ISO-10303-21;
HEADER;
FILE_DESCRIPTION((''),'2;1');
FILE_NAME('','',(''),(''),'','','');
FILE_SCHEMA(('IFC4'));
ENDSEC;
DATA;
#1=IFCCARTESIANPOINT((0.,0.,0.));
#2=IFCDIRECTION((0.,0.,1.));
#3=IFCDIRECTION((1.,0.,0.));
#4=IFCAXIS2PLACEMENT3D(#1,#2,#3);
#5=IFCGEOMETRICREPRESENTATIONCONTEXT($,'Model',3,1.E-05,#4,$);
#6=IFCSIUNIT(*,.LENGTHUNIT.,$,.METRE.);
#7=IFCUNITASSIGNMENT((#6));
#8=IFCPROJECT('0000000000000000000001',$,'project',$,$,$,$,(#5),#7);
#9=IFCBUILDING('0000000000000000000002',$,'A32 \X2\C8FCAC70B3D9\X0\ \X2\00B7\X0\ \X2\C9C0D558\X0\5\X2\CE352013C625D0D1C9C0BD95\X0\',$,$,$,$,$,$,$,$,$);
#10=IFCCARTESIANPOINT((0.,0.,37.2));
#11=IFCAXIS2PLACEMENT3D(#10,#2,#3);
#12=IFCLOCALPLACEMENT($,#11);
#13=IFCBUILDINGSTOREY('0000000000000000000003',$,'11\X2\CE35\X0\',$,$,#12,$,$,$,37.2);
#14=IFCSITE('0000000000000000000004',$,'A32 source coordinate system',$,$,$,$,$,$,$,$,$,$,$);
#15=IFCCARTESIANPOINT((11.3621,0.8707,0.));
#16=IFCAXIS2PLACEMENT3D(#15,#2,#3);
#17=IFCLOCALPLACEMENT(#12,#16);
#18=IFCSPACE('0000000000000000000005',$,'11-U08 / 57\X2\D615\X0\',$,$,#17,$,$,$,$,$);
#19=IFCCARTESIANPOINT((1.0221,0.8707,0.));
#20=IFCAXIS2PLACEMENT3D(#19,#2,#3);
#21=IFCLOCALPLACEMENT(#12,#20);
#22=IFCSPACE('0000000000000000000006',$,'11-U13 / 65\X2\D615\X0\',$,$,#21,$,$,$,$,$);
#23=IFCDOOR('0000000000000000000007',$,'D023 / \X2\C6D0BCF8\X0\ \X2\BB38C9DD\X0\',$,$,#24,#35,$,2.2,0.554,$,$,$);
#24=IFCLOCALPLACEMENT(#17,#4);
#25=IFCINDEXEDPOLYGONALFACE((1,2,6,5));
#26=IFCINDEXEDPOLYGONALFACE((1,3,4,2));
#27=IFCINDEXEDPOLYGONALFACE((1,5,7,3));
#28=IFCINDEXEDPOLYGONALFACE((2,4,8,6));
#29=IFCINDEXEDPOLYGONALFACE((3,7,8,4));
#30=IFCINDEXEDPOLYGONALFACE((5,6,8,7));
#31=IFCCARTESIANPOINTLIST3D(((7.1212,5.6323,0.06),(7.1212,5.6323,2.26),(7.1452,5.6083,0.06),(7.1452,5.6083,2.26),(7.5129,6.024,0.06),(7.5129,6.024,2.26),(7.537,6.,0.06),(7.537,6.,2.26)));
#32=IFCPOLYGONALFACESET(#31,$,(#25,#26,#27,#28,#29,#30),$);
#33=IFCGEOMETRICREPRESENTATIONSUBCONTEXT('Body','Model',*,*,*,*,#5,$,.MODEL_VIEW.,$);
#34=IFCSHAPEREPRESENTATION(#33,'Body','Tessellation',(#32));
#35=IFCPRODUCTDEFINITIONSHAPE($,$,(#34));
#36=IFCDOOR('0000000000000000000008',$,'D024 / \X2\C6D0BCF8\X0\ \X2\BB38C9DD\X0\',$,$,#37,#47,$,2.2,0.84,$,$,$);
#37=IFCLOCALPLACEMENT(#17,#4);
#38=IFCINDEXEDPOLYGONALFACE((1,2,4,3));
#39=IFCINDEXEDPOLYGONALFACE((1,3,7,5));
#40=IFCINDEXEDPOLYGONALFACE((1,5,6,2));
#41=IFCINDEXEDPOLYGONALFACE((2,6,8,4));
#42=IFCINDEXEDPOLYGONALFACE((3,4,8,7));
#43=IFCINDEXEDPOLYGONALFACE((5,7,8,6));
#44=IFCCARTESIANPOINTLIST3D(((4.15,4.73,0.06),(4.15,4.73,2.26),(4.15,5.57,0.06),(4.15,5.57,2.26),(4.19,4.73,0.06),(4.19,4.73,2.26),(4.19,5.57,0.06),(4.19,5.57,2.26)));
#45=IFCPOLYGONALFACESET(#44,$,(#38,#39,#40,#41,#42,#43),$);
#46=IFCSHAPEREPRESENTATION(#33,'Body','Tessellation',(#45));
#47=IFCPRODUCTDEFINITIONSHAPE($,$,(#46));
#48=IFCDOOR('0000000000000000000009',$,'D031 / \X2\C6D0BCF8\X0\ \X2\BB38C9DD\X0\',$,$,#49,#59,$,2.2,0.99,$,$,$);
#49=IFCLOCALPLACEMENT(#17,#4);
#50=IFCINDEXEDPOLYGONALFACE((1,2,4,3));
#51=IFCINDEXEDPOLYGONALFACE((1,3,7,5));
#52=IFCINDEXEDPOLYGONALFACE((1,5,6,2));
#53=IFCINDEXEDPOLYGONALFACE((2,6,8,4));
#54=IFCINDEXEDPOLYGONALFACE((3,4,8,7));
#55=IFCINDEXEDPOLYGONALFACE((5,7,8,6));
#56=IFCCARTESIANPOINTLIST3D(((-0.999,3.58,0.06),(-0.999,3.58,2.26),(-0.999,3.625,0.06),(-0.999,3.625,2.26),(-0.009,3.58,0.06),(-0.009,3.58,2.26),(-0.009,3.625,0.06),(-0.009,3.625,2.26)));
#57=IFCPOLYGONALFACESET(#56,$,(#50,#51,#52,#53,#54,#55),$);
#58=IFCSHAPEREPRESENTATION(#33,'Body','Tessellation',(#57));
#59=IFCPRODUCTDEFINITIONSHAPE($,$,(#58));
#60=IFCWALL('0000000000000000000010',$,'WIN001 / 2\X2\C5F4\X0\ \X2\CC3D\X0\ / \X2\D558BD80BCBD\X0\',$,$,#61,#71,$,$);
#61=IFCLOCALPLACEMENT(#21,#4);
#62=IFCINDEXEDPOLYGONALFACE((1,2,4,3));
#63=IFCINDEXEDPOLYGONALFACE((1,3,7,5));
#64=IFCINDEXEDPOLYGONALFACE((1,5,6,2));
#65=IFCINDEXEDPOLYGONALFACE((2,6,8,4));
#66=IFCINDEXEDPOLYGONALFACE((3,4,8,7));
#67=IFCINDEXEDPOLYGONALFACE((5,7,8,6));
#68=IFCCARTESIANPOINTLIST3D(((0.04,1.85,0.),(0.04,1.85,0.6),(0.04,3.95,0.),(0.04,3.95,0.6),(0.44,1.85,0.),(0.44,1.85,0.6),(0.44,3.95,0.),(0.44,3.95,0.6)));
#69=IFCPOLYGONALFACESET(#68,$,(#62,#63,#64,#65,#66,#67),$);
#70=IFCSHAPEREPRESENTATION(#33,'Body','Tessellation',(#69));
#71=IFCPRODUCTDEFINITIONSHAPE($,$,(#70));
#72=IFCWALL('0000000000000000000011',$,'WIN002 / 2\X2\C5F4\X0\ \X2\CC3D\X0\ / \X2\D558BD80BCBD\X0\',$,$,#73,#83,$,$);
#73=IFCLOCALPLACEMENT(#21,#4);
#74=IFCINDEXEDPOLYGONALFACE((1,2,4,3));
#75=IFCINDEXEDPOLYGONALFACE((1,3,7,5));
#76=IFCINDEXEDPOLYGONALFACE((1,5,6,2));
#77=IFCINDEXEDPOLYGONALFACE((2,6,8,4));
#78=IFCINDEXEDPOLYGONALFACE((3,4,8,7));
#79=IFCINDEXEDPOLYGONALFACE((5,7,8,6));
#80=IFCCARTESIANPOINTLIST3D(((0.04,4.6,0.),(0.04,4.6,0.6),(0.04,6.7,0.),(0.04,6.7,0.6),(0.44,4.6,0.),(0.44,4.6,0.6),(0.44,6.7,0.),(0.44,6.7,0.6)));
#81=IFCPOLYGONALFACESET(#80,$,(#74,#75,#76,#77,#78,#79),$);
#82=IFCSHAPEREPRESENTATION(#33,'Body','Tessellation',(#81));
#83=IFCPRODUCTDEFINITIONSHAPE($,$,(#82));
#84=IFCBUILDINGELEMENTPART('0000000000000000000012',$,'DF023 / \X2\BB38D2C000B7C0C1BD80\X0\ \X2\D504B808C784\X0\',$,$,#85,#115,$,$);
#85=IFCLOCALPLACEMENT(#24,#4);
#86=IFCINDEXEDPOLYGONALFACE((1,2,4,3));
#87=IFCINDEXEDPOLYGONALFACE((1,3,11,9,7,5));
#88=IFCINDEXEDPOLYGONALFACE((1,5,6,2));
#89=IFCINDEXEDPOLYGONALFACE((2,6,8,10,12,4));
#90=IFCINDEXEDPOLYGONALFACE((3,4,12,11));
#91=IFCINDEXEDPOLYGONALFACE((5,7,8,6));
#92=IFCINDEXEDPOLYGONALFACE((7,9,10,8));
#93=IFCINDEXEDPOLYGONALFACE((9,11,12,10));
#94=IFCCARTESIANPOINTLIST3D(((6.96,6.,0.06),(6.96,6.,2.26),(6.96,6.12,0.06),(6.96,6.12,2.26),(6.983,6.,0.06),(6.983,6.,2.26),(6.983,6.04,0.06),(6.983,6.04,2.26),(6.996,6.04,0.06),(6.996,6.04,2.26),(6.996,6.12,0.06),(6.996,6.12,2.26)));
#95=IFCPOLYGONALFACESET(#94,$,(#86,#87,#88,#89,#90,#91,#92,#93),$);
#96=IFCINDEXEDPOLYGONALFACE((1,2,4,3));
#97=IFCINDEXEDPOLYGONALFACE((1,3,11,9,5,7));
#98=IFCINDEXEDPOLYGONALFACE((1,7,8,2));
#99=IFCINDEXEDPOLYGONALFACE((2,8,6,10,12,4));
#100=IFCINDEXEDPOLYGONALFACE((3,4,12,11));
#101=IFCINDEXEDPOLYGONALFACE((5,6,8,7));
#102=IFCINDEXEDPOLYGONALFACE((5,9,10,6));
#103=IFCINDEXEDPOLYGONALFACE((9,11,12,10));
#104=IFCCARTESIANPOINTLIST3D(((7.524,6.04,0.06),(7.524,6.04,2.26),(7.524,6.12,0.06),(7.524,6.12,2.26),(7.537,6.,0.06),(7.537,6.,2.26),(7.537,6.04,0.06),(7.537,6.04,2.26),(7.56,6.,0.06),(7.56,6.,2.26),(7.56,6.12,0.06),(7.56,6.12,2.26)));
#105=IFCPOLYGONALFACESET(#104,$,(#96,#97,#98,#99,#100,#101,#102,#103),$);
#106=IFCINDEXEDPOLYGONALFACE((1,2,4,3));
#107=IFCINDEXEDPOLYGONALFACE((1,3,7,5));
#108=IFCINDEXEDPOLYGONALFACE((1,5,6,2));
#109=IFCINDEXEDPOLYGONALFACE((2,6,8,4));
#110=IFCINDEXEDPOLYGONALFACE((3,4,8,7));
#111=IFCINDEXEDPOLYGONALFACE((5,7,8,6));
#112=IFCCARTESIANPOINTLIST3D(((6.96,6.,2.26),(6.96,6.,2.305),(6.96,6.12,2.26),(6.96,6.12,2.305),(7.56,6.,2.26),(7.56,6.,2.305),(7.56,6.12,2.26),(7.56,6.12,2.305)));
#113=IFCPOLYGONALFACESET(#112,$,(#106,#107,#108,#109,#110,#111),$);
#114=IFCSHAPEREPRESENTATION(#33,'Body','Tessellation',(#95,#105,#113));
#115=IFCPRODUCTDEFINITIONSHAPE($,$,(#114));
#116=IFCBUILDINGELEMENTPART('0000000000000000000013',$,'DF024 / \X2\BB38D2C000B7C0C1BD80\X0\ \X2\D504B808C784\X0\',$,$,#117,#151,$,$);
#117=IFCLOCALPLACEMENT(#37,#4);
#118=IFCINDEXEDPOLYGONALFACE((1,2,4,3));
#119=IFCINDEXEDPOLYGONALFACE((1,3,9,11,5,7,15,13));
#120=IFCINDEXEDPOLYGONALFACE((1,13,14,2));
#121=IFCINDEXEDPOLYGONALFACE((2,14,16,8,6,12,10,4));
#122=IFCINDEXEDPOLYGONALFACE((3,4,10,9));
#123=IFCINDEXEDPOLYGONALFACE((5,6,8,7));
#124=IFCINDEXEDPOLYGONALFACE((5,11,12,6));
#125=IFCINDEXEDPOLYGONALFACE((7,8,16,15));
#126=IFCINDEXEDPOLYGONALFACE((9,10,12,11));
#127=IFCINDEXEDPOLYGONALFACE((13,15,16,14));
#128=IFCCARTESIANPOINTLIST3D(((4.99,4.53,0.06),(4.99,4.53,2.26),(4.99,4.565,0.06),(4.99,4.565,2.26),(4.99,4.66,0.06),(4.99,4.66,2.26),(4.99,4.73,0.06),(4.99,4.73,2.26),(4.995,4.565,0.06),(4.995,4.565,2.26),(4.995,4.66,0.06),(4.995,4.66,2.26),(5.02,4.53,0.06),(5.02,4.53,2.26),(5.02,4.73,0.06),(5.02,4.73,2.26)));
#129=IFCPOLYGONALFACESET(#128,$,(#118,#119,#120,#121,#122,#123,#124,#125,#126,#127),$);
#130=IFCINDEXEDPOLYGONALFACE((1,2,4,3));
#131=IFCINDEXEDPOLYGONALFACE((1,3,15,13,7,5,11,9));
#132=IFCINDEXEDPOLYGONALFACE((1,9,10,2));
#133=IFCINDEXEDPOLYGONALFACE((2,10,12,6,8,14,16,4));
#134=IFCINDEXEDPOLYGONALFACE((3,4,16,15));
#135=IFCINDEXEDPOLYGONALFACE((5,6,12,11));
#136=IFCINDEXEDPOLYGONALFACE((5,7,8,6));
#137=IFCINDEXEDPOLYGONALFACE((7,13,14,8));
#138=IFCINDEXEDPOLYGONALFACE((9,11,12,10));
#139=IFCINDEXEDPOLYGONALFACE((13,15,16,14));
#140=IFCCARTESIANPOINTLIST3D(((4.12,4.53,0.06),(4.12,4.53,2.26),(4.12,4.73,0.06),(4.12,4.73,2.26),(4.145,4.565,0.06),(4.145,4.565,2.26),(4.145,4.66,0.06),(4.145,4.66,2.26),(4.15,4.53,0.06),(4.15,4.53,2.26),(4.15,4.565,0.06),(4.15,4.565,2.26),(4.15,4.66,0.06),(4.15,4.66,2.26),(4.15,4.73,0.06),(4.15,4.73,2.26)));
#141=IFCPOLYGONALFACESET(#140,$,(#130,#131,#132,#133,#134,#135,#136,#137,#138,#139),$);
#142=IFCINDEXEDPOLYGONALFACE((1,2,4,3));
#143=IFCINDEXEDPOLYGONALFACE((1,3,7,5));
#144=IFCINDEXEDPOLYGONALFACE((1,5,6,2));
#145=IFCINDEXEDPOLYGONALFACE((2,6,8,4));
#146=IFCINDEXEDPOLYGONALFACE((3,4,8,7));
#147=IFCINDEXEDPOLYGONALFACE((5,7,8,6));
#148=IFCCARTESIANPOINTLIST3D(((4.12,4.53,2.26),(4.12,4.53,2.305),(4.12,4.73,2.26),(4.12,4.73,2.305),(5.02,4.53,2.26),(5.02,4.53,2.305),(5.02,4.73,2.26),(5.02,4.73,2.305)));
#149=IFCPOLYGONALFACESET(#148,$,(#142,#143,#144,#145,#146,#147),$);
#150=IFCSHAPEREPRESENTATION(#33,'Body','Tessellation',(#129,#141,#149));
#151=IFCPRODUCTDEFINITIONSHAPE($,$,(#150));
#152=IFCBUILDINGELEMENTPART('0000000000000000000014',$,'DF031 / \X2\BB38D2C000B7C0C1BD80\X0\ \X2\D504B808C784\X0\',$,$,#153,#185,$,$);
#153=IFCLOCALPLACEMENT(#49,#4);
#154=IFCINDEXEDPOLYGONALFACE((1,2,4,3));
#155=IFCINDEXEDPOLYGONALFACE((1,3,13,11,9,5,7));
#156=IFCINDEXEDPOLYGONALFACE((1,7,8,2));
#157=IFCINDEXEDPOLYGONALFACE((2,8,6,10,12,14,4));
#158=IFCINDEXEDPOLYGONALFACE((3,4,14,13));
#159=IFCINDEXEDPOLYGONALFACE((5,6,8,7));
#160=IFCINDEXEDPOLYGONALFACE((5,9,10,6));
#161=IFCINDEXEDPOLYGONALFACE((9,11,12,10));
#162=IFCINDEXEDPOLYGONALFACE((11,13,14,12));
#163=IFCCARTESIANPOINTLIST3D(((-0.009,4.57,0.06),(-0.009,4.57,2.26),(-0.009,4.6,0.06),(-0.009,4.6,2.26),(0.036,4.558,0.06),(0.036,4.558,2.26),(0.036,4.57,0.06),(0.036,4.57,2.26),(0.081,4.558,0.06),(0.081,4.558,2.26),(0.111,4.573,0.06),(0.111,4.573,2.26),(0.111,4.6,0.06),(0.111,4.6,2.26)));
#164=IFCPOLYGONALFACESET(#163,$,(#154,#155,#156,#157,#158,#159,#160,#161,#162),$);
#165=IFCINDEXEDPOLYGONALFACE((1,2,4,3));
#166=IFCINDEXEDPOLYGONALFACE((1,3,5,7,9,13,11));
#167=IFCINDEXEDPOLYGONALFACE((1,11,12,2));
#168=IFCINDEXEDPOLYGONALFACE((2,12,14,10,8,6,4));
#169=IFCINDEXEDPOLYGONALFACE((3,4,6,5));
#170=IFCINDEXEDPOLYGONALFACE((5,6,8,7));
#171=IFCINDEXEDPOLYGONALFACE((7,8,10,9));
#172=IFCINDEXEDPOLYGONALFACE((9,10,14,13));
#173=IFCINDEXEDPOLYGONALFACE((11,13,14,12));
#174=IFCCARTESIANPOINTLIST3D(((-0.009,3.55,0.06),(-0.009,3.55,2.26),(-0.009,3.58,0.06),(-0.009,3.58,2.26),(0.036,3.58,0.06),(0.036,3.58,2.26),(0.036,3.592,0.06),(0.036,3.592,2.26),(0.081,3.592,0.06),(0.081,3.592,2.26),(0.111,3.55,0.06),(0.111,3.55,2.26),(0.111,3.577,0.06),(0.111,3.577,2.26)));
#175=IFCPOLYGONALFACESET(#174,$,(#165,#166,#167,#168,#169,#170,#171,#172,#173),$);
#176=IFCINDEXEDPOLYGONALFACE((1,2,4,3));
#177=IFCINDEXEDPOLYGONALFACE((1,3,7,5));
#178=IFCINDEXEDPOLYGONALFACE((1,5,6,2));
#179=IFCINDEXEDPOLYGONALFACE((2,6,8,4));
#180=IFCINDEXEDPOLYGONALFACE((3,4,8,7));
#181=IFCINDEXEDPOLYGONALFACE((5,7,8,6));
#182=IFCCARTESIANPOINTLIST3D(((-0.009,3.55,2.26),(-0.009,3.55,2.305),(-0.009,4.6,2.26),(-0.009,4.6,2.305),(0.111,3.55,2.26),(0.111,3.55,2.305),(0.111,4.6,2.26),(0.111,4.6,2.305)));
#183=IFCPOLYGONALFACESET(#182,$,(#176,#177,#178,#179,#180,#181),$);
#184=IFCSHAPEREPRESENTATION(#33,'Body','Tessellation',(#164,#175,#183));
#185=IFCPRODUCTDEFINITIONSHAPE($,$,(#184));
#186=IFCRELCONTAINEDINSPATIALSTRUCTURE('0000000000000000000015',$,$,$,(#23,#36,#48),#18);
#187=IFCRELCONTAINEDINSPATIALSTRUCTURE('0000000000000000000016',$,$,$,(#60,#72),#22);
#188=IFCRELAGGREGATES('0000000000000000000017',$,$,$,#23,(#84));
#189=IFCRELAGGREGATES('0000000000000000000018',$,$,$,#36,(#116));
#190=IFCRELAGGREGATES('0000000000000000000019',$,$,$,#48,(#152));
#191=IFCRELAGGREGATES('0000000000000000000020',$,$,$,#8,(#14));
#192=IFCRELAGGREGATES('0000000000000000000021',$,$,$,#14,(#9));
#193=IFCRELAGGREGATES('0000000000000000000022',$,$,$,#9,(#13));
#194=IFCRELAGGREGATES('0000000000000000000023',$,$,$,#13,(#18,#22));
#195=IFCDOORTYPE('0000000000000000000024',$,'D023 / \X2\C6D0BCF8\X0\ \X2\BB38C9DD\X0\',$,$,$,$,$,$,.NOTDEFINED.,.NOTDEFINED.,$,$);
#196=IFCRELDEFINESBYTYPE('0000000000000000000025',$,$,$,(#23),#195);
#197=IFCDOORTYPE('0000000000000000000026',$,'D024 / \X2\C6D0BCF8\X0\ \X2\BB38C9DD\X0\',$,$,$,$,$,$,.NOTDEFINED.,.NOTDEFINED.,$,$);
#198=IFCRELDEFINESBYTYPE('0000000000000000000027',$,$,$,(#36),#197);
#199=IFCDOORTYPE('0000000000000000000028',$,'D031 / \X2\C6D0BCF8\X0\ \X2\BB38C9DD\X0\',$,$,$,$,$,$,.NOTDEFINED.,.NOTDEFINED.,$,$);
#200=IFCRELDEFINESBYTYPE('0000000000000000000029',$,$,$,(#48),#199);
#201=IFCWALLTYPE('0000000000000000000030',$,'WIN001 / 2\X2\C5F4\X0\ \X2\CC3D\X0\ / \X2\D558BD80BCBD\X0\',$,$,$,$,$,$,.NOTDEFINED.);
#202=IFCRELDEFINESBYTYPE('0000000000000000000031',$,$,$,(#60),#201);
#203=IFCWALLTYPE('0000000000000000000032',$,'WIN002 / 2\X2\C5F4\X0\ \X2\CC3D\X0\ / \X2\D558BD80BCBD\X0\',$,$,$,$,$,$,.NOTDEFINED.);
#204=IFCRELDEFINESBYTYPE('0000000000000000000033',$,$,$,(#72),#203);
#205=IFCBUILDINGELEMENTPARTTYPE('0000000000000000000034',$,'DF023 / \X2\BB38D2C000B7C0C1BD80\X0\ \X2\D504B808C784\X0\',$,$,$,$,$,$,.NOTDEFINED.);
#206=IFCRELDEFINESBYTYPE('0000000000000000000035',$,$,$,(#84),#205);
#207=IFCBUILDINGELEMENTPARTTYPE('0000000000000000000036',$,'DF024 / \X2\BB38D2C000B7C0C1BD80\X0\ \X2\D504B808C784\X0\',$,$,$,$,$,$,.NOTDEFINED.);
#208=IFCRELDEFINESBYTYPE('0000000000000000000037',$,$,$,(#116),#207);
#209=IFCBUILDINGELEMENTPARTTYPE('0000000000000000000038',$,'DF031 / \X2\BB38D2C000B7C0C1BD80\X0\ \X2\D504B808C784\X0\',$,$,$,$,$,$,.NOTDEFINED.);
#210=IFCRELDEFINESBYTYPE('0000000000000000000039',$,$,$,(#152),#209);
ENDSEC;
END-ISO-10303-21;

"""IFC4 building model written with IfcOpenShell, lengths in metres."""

from ifc_helpers import new_model, si_unit, frame, origin, origin_with_axes, place, context, subcontext, project, spatial, polyline, outline, extrude, source, transform, mapped, type_object, type_shapes, element, aggregate, save


model = new_model("IFC4")

# Units and contexts
model_context = context("Model", 3, precision=1e-05, world=origin_with_axes())
body_context = subcontext(model_context, "Body", "Model", "MODEL_VIEW")
ifc_project = project(units=[si_unit("LENGTHUNIT", "METRE")], contexts=[model_context])

# Site, building, storey, space
site = spatial("IfcSite", under=ifc_project, Name="A32 source coordinate system")
building = spatial("IfcBuilding", under=site, Name="A32 주거동 · 지하5층–옥탑지붕")
storey_placement = place(None, frame((0.0, 0.0, 37.2), z_axis=(0.0, 0.0, 1.0), x_axis=(1.0, 0.0, 0.0)))
storey = spatial("IfcBuildingStorey", under=building, at=storey_placement, Name="11층", Elevation=37.2)
space_1_placement = place(storey_placement, frame((11.3621, 0.8707, 0.0), z_axis=(0.0, 0.0, 1.0), x_axis=(1.0, 0.0, 0.0)))
space_1 = spatial("IfcSpace", under=storey, at=space_1_placement, Name="11-U08 / 57형")

# Doors
door_type_1 = type_object("IfcDoorType", Name="D023 / 원본 문짝", OperationType="NOTDEFINED", PredefinedType="NOTDEFINED")
shared_shape_1 = source(origin(), body_context, "Body", "SweptSolid", [
    extrude(outline(polyline([(7.537, 6.0), (7.1452, 5.6083), (7.1212, 5.6323), (7.5129, 6.024), (7.537, 6.0)])), frame((0.0, 0.0, 0.06)), (0.0, 0.0, 1.0), 2.2),
])
type_shapes(door_type_1, [shared_shape_1])
door_1_placement = place(space_1_placement, origin_with_axes())
door_1 = element("IfcDoor", 1, at=door_1_placement, inside=space_1, type_object=door_type_1, Name="D023 / 원본 문짝", OverallHeight=2.2, OverallWidth=0.554, context=body_context, shape_type="MappedRepresentation", body=[
    mapped(shared_shape_1, transform((0.0, 0.0, 0.0), scale=1.0)),
])
door_type_2 = type_object("IfcDoorType", Name="D024 / 원본 문짝", OperationType="NOTDEFINED", PredefinedType="NOTDEFINED")
shared_shape_2 = source(origin(), body_context, "Body", "SweptSolid", [
    extrude(outline(polyline([(4.15, 4.73), (4.15, 5.57), (4.19, 5.57), (4.19, 4.73), (4.15, 4.73)])), frame((0.0, 0.0, 0.06)), (0.0, 0.0, 1.0), 2.2),
])
type_shapes(door_type_2, [shared_shape_2])
door_2_placement = place(space_1_placement, origin_with_axes())
door_2 = element("IfcDoor", 2, at=door_2_placement, inside=space_1, type_object=door_type_2, Name="D024 / 원본 문짝", OverallHeight=2.2, OverallWidth=0.84, context=body_context, shape_type="MappedRepresentation", body=[
    mapped(shared_shape_2, transform((0.0, 0.0, 0.0), scale=1.0)),
])
door_type_3 = type_object("IfcDoorType", Name="D031 / 원본 문짝", OperationType="NOTDEFINED", PredefinedType="NOTDEFINED")
shared_shape_3 = source(origin(), body_context, "Body", "SweptSolid", [
    extrude(outline(polyline([(-0.009, 3.58), (-0.999, 3.58), (-0.999, 3.625), (-0.009, 3.625), (-0.009, 3.58)])), frame((0.0, 0.0, 0.06)), (0.0, 0.0, 1.0), 2.2),
])
type_shapes(door_type_3, [shared_shape_3])
door_3_placement = place(space_1_placement, origin_with_axes())
door_3 = element("IfcDoor", 3, at=door_3_placement, inside=space_1, type_object=door_type_3, Name="D031 / 원본 문짝", OverallHeight=2.2, OverallWidth=0.99, context=body_context, shape_type="MappedRepresentation", body=[
    mapped(shared_shape_3, transform((0.0, 0.0, 0.0), scale=1.0)),
])

# Shared definitions
space_2_placement = place(storey_placement, frame((1.0221, 0.8707, 0.0), z_axis=(0.0, 0.0, 1.0), x_axis=(1.0, 0.0, 0.0)))
space_2 = spatial("IfcSpace", under=storey, at=space_2_placement, Name="11-U13 / 65형")

# Walls
wall_type_1 = type_object("IfcWallType", Name="WIN001 / 2열 창 / 하부벽", PredefinedType="NOTDEFINED")
shared_shape_4 = source(origin(), body_context, "Body", "SweptSolid", [
    extrude(outline(polyline([(0.04, 3.95), (0.44, 3.95), (0.44, 1.85), (0.04, 1.85), (0.04, 3.95)])), origin(), (0.0, 0.0, 1.0), 0.6),
])
type_shapes(wall_type_1, [shared_shape_4])
wall_1_placement = place(space_2_placement, origin_with_axes())
element("IfcWall", 4, at=wall_1_placement, inside=space_2, type_object=wall_type_1, Name="WIN001 / 2열 창 / 하부벽", context=body_context, shape_type="MappedRepresentation", body=[
    mapped(shared_shape_4, transform((0.0, 0.0, 0.0), scale=1.0)),
])
wall_type_2 = type_object("IfcWallType", Name="WIN002 / 2열 창 / 하부벽", PredefinedType="NOTDEFINED")
shared_shape_5 = source(origin(), body_context, "Body", "SweptSolid", [
    extrude(outline(polyline([(0.04, 6.7), (0.44, 6.7), (0.44, 4.6), (0.04, 4.6), (0.04, 6.7)])), origin(), (0.0, 0.0, 1.0), 0.6),
])
type_shapes(wall_type_2, [shared_shape_5])
wall_2_placement = place(space_2_placement, origin_with_axes())
element("IfcWall", 5, at=wall_2_placement, inside=space_2, type_object=wall_type_2, Name="WIN002 / 2열 창 / 하부벽", context=body_context, shape_type="MappedRepresentation", body=[
    mapped(shared_shape_5, transform((0.0, 0.0, 0.0), scale=1.0)),
])

# Building element parts
building_element_part_type_1 = type_object("IfcBuildingElementPartType", Name="DF023 / 문틀·상부 프레임", PredefinedType="NOTDEFINED")
shared_shape_6 = source(origin(), body_context, "Body", "SweptSolid", [
    extrude(outline(polyline([(6.996, 6.12), (6.996, 6.04), (6.983, 6.04), (6.983, 6.0), (6.96, 6.0), (6.96, 6.12), (6.996, 6.12)])), frame((0.0, 0.0, 0.06)), (0.0, 0.0, 1.0), 2.2),
    extrude(outline(polyline([(7.56, 6.0), (7.537, 6.0), (7.537, 6.04), (7.524, 6.04), (7.524, 6.12), (7.56, 6.12), (7.56, 6.0)])), frame((0.0, 0.0, 0.06)), (0.0, 0.0, 1.0), 2.2),
    extrude(outline(polyline([(6.96, 6.0), (6.96, 6.12), (7.56, 6.12), (7.56, 6.0), (6.96, 6.0)])), frame((0.0, 0.0, 2.26)), (0.0, 0.0, 1.0), 0.045),
])
type_shapes(building_element_part_type_1, [shared_shape_6])
building_element_part_1_placement = place(door_1_placement, origin_with_axes())
building_element_part_1 = element("IfcBuildingElementPart", 6, at=building_element_part_1_placement, type_object=building_element_part_type_1, Name="DF023 / 문틀·상부 프레임", context=body_context, shape_type="MappedRepresentation", body=[
    mapped(shared_shape_6, transform((0.0, 0.0, 0.0), scale=1.0)),
])
aggregate(door_1, [building_element_part_1])
building_element_part_type_2 = type_object("IfcBuildingElementPartType", Name="DF024 / 문틀·상부 프레임", PredefinedType="NOTDEFINED")
shared_shape_7 = source(origin(), body_context, "Body", "SweptSolid", [
    extrude(outline(polyline([(5.02, 4.53), (4.99, 4.53), (4.99, 4.565), (4.995, 4.565), (4.995, 4.66), (4.99, 4.66), (4.99, 4.73), (5.02, 4.73), (5.02, 4.53)])), frame((0.0, 0.0, 0.06)), (0.0, 0.0, 1.0), 2.2),
    extrude(outline(polyline([(4.15, 4.73), (4.15, 4.66), (4.145, 4.66), (4.145, 4.565), (4.15, 4.565), (4.15, 4.53), (4.12, 4.53), (4.12, 4.73), (4.15, 4.73)])), frame((0.0, 0.0, 0.06)), (0.0, 0.0, 1.0), 2.2),
    extrude(outline(polyline([(4.12, 4.53), (4.12, 4.73), (5.02, 4.73), (5.02, 4.53), (4.12, 4.53)])), frame((0.0, 0.0, 2.26)), (0.0, 0.0, 1.0), 0.045),
])
type_shapes(building_element_part_type_2, [shared_shape_7])
building_element_part_2_placement = place(door_2_placement, origin_with_axes())
building_element_part_2 = element("IfcBuildingElementPart", 7, at=building_element_part_2_placement, type_object=building_element_part_type_2, Name="DF024 / 문틀·상부 프레임", context=body_context, shape_type="MappedRepresentation", body=[
    mapped(shared_shape_7, transform((0.0, 0.0, 0.0), scale=1.0)),
])
aggregate(door_2, [building_element_part_2])
building_element_part_type_3 = type_object("IfcBuildingElementPartType", Name="DF031 / 문틀·상부 프레임", PredefinedType="NOTDEFINED")
shared_shape_8 = source(origin(), body_context, "Body", "SweptSolid", [
    extrude(outline(polyline([(0.111, 4.6), (0.111, 4.573), (0.081, 4.558), (0.036, 4.558), (0.036, 4.57), (-0.009, 4.57), (-0.009, 4.6), (0.111, 4.6)])), frame((0.0, 0.0, 0.06)), (0.0, 0.0, 1.0), 2.2),
    extrude(outline(polyline([(-0.009, 3.58), (0.036, 3.58), (0.036, 3.592), (0.081, 3.592), (0.111, 3.577), (0.111, 3.55), (-0.009, 3.55), (-0.009, 3.58)])), frame((0.0, 0.0, 0.06)), (0.0, 0.0, 1.0), 2.2),
    extrude(outline(polyline([(-0.009, 3.55), (-0.009, 4.6), (0.111, 4.6), (0.111, 3.55), (-0.009, 3.55)])), frame((0.0, 0.0, 2.26)), (0.0, 0.0, 1.0), 0.045),
])
type_shapes(building_element_part_type_3, [shared_shape_8])
building_element_part_3_placement = place(door_3_placement, origin_with_axes())
building_element_part_3 = element("IfcBuildingElementPart", 8, at=building_element_part_3_placement, type_object=building_element_part_type_3, Name="DF031 / 문틀·상부 프레임", context=body_context, shape_type="MappedRepresentation", body=[
    mapped(shared_shape_8, transform((0.0, 0.0, 0.0), scale=1.0)),
])
aggregate(door_3, [building_element_part_3])

save(model, "model.ifc")
